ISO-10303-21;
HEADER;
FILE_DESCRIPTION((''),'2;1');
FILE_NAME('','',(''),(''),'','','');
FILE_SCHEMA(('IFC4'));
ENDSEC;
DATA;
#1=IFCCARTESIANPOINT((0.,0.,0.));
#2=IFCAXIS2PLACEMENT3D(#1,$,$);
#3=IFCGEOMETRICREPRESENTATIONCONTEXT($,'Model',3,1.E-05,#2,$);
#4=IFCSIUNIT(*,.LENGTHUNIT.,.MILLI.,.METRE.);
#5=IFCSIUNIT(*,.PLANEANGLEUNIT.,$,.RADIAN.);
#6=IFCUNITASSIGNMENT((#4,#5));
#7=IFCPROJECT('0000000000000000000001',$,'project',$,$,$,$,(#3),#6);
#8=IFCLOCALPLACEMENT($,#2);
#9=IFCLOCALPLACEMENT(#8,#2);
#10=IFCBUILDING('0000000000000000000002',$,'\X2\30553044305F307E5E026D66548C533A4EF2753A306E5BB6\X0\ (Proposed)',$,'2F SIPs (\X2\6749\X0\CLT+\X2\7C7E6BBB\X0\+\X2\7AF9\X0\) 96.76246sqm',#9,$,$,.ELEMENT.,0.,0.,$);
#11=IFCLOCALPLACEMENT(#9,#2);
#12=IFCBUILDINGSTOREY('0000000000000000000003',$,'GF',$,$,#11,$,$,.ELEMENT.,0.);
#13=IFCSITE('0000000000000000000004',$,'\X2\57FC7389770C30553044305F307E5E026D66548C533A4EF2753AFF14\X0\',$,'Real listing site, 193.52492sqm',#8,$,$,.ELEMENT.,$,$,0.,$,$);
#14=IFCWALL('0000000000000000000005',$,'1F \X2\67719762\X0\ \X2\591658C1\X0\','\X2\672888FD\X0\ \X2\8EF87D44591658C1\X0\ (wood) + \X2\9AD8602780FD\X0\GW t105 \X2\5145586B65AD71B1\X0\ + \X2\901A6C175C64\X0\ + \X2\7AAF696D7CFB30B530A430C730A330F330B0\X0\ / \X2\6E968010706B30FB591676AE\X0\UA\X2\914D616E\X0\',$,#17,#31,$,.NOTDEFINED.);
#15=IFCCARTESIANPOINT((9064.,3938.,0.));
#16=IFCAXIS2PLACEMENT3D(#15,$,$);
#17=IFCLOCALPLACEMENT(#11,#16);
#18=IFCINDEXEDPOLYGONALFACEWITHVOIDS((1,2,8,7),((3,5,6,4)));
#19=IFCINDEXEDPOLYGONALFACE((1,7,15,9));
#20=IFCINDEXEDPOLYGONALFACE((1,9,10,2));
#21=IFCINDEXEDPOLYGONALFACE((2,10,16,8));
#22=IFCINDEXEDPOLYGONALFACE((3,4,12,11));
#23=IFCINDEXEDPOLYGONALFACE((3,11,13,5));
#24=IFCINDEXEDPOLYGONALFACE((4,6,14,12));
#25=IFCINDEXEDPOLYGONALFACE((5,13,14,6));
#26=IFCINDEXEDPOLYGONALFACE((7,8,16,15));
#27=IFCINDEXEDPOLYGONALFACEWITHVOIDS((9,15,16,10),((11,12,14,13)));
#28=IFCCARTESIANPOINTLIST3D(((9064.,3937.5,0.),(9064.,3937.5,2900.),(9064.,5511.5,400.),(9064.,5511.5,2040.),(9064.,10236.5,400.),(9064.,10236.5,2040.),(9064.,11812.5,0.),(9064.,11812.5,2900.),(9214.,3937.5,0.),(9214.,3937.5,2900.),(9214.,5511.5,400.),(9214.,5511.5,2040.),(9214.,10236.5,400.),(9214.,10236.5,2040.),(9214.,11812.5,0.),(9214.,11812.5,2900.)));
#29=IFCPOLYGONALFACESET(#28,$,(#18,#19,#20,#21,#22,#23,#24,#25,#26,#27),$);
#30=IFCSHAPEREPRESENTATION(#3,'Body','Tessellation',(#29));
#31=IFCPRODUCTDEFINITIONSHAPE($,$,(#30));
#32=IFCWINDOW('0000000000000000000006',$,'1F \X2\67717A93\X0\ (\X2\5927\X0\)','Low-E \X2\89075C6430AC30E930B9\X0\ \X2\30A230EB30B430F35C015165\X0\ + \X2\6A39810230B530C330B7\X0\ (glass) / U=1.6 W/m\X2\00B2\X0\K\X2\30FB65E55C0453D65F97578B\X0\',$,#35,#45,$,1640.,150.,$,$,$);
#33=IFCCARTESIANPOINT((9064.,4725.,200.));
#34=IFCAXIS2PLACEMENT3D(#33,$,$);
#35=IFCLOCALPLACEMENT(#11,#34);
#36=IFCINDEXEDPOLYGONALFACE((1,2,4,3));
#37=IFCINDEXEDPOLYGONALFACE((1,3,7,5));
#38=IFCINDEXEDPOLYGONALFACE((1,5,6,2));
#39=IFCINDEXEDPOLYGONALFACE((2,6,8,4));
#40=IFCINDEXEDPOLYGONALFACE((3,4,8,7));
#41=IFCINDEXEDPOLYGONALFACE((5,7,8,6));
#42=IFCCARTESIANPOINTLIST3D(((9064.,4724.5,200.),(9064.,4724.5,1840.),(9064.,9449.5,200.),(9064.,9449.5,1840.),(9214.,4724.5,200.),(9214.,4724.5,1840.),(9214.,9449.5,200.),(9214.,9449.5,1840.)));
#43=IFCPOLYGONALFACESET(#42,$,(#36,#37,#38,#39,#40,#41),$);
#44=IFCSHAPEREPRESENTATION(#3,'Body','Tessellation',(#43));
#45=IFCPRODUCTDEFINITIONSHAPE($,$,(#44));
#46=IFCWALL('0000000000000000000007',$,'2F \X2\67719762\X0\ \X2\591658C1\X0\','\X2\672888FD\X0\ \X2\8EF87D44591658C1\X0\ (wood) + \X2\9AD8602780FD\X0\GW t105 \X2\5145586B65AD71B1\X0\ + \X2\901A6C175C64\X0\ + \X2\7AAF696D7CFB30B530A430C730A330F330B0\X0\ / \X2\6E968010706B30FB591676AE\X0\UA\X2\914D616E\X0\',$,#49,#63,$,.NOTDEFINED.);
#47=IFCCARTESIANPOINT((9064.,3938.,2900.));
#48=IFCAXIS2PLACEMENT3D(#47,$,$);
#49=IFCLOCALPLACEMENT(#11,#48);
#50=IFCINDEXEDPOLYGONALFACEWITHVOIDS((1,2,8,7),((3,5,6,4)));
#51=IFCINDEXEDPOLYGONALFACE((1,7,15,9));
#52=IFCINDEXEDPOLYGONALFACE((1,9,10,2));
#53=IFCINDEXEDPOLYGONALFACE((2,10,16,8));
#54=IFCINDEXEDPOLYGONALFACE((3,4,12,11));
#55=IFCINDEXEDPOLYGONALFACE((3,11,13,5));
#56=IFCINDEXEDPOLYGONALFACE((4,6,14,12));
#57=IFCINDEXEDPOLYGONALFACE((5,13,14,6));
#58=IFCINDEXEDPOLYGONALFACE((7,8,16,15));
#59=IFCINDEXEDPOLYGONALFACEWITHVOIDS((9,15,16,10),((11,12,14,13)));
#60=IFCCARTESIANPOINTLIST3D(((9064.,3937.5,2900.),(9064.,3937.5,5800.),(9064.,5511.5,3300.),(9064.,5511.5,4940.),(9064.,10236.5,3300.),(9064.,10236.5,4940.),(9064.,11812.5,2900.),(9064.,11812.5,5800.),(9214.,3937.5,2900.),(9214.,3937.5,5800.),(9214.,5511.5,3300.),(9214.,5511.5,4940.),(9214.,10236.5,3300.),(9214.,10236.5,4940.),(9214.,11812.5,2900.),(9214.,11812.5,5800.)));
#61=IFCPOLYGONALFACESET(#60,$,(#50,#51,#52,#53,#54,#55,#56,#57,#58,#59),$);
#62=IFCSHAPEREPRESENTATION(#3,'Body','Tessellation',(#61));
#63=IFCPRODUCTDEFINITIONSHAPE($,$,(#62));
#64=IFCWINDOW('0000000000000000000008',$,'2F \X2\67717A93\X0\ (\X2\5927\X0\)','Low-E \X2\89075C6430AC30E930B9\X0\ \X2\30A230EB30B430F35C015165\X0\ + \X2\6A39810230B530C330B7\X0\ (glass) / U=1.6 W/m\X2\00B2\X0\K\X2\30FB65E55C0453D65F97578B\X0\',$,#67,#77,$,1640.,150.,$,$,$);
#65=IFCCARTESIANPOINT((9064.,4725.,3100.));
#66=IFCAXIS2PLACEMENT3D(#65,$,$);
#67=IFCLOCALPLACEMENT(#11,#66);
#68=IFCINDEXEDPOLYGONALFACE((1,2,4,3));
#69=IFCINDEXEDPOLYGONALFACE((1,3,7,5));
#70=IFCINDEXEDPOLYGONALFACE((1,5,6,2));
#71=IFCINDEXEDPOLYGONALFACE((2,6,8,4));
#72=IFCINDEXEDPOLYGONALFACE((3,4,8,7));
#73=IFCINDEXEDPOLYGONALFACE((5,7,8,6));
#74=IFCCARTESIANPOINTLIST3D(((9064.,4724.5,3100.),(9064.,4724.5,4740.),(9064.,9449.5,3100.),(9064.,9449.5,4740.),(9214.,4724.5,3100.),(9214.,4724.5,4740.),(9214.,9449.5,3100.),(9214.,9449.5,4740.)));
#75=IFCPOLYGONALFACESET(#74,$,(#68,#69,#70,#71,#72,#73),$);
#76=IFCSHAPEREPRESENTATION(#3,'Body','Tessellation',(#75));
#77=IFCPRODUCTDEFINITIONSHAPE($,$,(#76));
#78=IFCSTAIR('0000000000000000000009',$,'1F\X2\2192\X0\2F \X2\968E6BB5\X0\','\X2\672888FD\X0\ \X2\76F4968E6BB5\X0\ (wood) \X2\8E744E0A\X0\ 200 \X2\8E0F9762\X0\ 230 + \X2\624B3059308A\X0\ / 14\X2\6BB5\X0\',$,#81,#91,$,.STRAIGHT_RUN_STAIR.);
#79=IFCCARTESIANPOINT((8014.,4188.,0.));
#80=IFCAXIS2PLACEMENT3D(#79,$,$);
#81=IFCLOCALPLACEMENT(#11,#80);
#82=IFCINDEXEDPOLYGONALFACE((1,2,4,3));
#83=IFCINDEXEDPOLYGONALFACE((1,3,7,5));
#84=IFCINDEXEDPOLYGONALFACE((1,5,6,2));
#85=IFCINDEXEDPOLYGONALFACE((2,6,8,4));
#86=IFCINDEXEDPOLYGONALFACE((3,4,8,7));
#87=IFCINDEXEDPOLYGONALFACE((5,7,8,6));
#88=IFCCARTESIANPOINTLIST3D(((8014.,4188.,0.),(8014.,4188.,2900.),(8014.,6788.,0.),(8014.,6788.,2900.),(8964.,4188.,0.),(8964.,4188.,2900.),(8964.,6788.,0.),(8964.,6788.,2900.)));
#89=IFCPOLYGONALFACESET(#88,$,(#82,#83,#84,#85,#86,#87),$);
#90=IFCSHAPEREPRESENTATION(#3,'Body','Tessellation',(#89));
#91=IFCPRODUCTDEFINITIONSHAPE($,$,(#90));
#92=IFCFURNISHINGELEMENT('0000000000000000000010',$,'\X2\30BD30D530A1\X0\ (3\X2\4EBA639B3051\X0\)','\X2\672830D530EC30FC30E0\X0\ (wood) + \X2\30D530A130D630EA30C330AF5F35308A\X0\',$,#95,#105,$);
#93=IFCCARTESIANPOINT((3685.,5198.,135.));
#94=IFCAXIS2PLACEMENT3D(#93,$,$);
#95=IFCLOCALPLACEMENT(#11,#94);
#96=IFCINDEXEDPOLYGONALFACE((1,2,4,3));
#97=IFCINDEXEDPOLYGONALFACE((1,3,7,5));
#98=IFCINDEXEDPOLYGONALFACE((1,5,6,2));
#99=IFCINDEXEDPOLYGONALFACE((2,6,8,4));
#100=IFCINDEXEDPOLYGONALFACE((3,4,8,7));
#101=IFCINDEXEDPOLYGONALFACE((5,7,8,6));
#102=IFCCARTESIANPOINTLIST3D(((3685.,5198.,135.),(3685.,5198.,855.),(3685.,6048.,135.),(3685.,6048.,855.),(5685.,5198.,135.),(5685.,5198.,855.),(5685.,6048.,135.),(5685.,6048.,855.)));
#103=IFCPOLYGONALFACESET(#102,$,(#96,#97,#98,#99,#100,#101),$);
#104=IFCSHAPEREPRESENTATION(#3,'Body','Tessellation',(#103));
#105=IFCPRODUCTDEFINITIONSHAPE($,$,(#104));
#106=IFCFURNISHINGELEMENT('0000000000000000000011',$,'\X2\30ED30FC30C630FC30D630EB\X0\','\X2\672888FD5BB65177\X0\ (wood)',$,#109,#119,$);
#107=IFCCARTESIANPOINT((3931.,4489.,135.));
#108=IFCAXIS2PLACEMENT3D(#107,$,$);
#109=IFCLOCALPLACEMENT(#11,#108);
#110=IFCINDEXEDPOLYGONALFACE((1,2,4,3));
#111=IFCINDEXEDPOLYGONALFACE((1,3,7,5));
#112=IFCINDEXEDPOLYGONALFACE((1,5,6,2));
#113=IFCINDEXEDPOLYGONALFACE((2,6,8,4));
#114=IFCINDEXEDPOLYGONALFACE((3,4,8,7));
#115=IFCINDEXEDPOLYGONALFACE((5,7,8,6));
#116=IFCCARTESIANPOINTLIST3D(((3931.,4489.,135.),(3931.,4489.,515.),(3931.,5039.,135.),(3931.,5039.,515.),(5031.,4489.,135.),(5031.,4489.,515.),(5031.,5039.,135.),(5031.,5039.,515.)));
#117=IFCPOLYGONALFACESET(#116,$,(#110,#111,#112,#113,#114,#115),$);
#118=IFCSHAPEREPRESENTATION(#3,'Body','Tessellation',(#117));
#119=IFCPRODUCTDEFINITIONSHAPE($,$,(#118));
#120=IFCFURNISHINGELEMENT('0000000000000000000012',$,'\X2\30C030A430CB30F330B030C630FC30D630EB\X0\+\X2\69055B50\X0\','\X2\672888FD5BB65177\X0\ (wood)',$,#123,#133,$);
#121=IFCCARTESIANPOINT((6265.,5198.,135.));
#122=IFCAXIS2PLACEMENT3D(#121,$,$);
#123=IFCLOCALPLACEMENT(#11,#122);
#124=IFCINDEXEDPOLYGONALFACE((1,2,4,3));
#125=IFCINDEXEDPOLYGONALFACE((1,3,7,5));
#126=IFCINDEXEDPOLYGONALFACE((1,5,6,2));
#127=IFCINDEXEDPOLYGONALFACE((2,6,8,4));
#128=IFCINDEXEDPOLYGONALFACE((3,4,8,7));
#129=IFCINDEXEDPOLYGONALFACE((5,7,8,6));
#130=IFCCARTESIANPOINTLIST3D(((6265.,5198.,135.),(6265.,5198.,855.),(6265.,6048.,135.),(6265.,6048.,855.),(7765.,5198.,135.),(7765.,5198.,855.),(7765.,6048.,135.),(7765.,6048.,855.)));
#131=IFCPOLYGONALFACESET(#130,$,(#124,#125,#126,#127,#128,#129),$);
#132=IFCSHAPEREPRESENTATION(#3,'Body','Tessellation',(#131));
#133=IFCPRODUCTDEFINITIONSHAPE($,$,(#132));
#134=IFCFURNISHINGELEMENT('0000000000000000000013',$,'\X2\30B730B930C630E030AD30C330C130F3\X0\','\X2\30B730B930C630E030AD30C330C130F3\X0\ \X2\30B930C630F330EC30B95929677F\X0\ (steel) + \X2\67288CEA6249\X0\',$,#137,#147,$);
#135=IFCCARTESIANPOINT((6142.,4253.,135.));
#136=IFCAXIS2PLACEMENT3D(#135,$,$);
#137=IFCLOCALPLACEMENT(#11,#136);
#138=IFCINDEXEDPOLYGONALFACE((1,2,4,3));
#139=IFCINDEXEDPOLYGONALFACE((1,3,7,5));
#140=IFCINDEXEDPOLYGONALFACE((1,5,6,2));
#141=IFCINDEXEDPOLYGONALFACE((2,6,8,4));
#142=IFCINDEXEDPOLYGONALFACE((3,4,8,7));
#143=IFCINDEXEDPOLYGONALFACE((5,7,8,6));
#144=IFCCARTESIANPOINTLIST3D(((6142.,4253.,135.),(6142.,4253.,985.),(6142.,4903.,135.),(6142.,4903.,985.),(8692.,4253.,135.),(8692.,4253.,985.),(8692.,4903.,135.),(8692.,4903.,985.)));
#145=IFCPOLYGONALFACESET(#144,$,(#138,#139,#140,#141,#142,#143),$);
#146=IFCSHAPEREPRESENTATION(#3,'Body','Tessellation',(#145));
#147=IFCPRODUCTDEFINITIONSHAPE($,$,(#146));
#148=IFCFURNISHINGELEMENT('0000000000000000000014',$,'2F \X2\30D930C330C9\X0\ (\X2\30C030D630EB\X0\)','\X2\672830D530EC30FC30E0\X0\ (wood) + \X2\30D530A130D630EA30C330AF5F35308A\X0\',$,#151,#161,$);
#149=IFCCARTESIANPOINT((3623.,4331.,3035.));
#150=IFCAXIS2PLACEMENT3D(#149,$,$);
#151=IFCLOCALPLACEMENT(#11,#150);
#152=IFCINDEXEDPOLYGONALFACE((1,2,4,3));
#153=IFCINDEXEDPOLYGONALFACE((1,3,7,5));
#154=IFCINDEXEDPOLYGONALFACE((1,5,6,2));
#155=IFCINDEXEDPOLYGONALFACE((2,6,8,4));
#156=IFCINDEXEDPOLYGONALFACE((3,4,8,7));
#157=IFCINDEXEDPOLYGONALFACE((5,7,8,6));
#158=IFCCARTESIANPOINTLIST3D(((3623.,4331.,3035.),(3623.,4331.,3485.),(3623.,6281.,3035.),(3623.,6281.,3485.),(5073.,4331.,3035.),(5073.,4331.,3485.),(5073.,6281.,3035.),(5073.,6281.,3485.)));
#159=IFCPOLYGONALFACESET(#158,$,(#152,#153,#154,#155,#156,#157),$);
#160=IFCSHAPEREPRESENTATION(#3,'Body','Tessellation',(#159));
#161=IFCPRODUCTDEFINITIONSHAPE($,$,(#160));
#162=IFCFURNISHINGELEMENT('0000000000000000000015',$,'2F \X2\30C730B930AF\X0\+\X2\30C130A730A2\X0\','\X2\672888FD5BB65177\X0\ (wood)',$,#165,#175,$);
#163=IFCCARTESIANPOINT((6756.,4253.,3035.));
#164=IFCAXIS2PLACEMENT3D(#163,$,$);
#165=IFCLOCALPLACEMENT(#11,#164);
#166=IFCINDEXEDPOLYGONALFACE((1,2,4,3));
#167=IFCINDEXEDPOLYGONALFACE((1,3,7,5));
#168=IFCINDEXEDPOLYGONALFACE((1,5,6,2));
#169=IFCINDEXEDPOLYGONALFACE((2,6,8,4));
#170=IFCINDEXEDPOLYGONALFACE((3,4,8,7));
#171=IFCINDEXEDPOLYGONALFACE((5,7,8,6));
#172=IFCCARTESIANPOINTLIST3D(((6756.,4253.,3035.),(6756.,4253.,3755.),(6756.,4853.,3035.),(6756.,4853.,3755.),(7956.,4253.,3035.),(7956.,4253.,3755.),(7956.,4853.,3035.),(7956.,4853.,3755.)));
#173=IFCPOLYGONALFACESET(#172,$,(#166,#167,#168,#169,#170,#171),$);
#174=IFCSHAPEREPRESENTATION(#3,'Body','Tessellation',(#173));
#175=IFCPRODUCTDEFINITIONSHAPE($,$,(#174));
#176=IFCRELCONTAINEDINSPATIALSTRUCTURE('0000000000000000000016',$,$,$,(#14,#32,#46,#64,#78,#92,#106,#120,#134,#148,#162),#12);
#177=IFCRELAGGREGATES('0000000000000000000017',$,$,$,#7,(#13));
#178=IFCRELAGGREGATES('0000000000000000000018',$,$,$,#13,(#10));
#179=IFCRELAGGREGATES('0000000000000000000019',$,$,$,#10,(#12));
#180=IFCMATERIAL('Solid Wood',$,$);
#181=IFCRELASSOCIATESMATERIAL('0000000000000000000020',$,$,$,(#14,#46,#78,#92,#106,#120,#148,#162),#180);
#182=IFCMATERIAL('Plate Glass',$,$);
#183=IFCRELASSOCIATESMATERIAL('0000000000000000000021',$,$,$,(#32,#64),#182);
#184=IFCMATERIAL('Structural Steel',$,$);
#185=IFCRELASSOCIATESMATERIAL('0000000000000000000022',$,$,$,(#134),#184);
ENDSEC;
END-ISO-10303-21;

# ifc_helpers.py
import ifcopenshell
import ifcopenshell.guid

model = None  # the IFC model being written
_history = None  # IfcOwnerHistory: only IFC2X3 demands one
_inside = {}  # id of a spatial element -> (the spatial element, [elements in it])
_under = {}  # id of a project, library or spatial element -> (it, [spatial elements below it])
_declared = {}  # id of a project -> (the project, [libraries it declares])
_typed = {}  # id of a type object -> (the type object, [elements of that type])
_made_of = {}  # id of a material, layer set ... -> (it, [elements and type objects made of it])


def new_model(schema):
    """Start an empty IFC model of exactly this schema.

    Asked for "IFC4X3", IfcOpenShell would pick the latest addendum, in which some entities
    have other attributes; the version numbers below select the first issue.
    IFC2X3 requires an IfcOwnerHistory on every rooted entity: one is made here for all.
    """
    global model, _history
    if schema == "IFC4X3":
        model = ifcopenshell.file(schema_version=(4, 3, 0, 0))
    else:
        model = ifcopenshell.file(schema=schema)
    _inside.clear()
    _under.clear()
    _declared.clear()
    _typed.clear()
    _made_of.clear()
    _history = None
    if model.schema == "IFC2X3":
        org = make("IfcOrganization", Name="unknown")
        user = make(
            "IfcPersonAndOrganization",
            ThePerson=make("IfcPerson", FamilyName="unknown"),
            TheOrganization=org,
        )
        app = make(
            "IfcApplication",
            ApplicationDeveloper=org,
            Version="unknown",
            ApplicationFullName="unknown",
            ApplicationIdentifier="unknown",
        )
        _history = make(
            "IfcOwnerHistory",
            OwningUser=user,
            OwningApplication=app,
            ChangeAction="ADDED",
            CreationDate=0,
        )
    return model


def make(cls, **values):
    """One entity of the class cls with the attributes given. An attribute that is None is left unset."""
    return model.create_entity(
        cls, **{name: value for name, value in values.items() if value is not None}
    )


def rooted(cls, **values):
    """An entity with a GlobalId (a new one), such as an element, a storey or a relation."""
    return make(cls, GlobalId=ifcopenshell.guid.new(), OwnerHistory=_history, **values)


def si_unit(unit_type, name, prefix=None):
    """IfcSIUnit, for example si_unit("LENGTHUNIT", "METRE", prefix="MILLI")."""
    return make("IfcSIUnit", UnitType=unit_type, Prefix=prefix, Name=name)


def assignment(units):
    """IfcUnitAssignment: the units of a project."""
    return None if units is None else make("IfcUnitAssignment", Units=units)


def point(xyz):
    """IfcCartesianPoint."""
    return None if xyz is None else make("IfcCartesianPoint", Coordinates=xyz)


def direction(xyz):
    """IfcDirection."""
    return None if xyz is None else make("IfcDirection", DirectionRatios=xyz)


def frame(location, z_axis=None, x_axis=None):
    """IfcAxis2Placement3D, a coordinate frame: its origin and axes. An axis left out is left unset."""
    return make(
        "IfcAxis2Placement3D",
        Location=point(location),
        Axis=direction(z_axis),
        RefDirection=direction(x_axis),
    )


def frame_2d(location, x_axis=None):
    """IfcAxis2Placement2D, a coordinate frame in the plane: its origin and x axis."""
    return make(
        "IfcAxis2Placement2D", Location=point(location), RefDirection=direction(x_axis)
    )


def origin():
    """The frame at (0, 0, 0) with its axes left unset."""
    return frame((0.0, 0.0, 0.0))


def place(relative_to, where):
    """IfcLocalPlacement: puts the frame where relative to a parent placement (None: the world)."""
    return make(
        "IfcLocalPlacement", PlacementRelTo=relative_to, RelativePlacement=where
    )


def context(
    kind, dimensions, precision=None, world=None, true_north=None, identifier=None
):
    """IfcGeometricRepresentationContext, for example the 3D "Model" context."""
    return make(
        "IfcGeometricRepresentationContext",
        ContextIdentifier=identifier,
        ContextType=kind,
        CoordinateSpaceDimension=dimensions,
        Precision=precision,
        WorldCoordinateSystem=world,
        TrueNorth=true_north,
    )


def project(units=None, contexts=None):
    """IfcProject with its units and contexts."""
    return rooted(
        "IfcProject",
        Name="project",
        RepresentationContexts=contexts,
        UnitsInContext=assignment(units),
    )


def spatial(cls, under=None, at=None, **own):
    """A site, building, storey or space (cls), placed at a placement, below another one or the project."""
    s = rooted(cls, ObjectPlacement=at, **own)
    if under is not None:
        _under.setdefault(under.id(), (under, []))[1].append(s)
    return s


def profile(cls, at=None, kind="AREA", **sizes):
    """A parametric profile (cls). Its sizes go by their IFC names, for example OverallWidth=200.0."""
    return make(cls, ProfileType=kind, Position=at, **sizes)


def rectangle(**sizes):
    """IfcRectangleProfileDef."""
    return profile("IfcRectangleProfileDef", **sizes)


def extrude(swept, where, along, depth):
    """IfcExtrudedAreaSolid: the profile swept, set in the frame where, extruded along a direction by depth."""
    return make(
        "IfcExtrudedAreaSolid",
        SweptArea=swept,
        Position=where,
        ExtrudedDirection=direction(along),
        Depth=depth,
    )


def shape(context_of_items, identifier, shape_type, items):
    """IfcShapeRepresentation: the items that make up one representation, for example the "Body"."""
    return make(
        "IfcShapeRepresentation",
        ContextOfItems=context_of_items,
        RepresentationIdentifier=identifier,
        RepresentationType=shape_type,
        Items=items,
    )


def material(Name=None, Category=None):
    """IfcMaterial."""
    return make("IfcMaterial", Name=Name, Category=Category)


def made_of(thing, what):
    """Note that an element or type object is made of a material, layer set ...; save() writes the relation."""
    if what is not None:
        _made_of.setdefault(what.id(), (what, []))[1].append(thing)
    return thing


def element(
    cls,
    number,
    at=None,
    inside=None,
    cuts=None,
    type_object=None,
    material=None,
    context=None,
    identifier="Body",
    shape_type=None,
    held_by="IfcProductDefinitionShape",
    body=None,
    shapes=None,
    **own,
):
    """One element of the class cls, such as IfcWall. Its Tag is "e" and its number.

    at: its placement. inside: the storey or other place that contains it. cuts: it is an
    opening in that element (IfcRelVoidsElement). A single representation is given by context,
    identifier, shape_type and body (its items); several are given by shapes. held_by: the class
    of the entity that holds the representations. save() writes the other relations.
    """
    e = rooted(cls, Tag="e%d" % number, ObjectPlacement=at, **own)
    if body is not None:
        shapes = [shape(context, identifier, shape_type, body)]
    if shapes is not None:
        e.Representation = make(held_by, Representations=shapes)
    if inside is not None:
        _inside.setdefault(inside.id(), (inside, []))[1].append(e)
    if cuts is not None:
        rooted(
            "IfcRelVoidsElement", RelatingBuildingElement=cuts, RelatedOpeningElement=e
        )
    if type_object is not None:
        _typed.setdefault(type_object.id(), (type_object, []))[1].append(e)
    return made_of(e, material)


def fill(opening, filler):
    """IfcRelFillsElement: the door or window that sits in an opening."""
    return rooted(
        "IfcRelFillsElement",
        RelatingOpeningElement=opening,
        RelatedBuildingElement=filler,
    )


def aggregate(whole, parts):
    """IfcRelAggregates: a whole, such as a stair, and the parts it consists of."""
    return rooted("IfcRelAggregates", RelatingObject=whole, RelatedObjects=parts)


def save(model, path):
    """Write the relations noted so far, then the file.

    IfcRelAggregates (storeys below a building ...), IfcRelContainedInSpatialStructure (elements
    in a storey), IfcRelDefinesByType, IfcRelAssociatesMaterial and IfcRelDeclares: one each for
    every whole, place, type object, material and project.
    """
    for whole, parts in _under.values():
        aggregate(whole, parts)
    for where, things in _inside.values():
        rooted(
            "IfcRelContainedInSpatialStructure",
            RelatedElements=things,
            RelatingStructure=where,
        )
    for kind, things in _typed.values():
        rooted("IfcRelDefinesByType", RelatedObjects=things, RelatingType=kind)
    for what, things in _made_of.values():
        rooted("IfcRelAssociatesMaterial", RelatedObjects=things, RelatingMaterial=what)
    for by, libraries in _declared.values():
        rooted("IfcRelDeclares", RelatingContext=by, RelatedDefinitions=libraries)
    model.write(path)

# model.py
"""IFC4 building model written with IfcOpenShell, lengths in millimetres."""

from ifc_helpers import new_model, si_unit, frame, frame_2d, origin, place, context, project, spatial, rectangle, extrude, material, element, fill, save


model = new_model("IFC4")

# Units and contexts
model_context = context("Model", 3, precision=1e-05, world=origin())
ifc_project = project(units=[si_unit("LENGTHUNIT", "METRE", prefix="MILLI"), si_unit("PLANEANGLEUNIT", "RADIAN")], contexts=[model_context])

# Site, building, storey
site_placement = place(None, origin())
site = spatial("IfcSite", under=ifc_project, at=site_placement, Name="埼玉県さいたま市浦和区仲町４", ObjectType="Real listing site, 193.52492sqm", CompositionType="ELEMENT", RefElevation=0.0)
building_placement = place(site_placement, origin())
building = spatial("IfcBuilding", under=site, at=building_placement, Name="さいたま市浦和区仲町の家 (Proposed)", ObjectType="2F SIPs (杉CLT+籾殻+竹) 96.76246sqm", CompositionType="ELEMENT", ElevationOfRefHeight=0.0, ElevationOfTerrain=0.0)
storey_placement = place(building_placement, origin())
storey = spatial("IfcBuildingStorey", under=building, at=storey_placement, Name="GF", CompositionType="ELEMENT", Elevation=0.0)

# Wall, opening, window
ifc_material_1 = material(Name="Solid Wood")
wall_1_placement = place(storey_placement, frame((9064.0, 3938.0, 0.0)))
wall_1 = element("IfcWall", 1, at=wall_1_placement, inside=storey, material=ifc_material_1, Name="1F 東面 外壁", Description="木製 軸組外壁 (wood) + 高性能GW t105 充填断熱 + 通気層 + 窯業系サイディング / 準耐火・外皮UA配慮", PredefinedType="NOTDEFINED", context=model_context, shape_type="SweptSolid", body=[
    extrude(rectangle(XDim=150.0, YDim=7875.0, at=frame_2d((75.0, 3937.0))), frame((9064.0, 3938.0, 0.0)), (0.0, 0.0, 1.0), 2900.0),
])
opening_1_placement = place(storey_placement, frame((9064.0, 4725.0, 200.0)))
opening_1 = element("IfcOpeningElement", 2, at=opening_1_placement, cuts=wall_1, PredefinedType="NOTDEFINED", context=model_context, shape_type="SweptSolid", body=[
    extrude(rectangle(XDim=150.0, YDim=4725.0, at=frame_2d((75.0, 2362.0))), frame((9064.0, 4725.0, 200.0)), (0.0, 0.0, 1.0), 1640.0),
])
ifc_material_2 = material(Name="Plate Glass")
window_1_placement = place(storey_placement, frame((9064.0, 4725.0, 200.0)))
window_1 = element("IfcWindow", 3, at=window_1_placement, inside=storey, material=ifc_material_2, Name="1F 東窓 (大)", Description="Low-E 複層ガラス アルゴン封入 + 樹脂サッシ (glass) / U=1.6 W/m²K・日射取得型", OverallHeight=1640.0, OverallWidth=150.0, context=model_context, shape_type="SweptSolid", body=[
    extrude(rectangle(XDim=150.0, YDim=4725.0, at=frame_2d((75.0, 2362.0))), frame((9064.0, 4725.0, 200.0)), (0.0, 0.0, 1.0), 1640.0),
])
fill(opening_1, window_1)

# Wall, opening, window
wall_2_placement = place(storey_placement, frame((9064.0, 3938.0, 2900.0)))
wall_2 = element("IfcWall", 4, at=wall_2_placement, inside=storey, material=ifc_material_1, Name="2F 東面 外壁", Description="木製 軸組外壁 (wood) + 高性能GW t105 充填断熱 + 通気層 + 窯業系サイディング / 準耐火・外皮UA配慮", PredefinedType="NOTDEFINED", context=model_context, shape_type="SweptSolid", body=[
    extrude(rectangle(XDim=150.0, YDim=7875.0, at=frame_2d((75.0, 3937.0))), frame((9064.0, 3938.0, 2900.0)), (0.0, 0.0, 1.0), 2900.0),
])
opening_2_placement = place(storey_placement, frame((9064.0, 4725.0, 3100.0)))
opening_2 = element("IfcOpeningElement", 5, at=opening_2_placement, cuts=wall_2, PredefinedType="NOTDEFINED", context=model_context, shape_type="SweptSolid", body=[
    extrude(rectangle(XDim=150.0, YDim=4725.0, at=frame_2d((75.0, 2362.0))), frame((9064.0, 4725.0, 3100.0)), (0.0, 0.0, 1.0), 1640.0),
])
window_2_placement = place(storey_placement, frame((9064.0, 4725.0, 3100.0)))
window_2 = element("IfcWindow", 6, at=window_2_placement, inside=storey, material=ifc_material_2, Name="2F 東窓 (大)", Description="Low-E 複層ガラス アルゴン封入 + 樹脂サッシ (glass) / U=1.6 W/m²K・日射取得型", OverallHeight=1640.0, OverallWidth=150.0, context=model_context, shape_type="SweptSolid", body=[
    extrude(rectangle(XDim=150.0, YDim=4725.0, at=frame_2d((75.0, 2362.0))), frame((9064.0, 4725.0, 3100.0)), (0.0, 0.0, 1.0), 1640.0),
])
fill(opening_2, window_2)

# Stair
stair_placement = place(storey_placement, frame((8014.0, 4188.0, 0.0)))
element("IfcStair", 7, at=stair_placement, inside=storey, material=ifc_material_1, Name="1F→2F 階段", Description="木製 直階段 (wood) 蹴上 200 踏面 230 + 手すり / 14段", PredefinedType="STRAIGHT_RUN_STAIR", context=model_context, shape_type="SweptSolid", body=[
    extrude(rectangle(XDim=950.0, YDim=2600.0, at=frame_2d((475.0, 1300.0))), frame((8014.0, 4188.0, 0.0)), (0.0, 0.0, 1.0), 2900.0),
])

# Furnishing elements
furnishing_1_placement = place(storey_placement, frame((3685.0, 5198.0, 135.0)))
element("IfcFurnishingElement", 8, at=furnishing_1_placement, inside=storey, material=ifc_material_1, Name="ソファ (3人掛け)", Description="木フレーム (wood) + ファブリック張り", context=model_context, shape_type="SweptSolid", body=[
    extrude(rectangle(XDim=2000.0, YDim=850.0, at=frame_2d((1000.0, 425.0))), frame((3685.0, 5198.0, 135.0)), (0.0, 0.0, 1.0), 720.0),
])
furnishing_2_placement = place(storey_placement, frame((3931.0, 4489.0, 135.0)))
element("IfcFurnishingElement", 9, at=furnishing_2_placement, inside=storey, material=ifc_material_1, Name="ローテーブル", Description="木製家具 (wood)", context=model_context, shape_type="SweptSolid", body=[
    extrude(rectangle(XDim=1100.0, YDim=550.0, at=frame_2d((550.0, 275.0))), frame((3931.0, 4489.0, 135.0)), (0.0, 0.0, 1.0), 380.0),
])
furnishing_3_placement = place(storey_placement, frame((6265.0, 5198.0, 135.0)))
element("IfcFurnishingElement", 10, at=furnishing_3_placement, inside=storey, material=ifc_material_1, Name="ダイニングテーブル+椅子", Description="木製家具 (wood)", context=model_context, shape_type="SweptSolid", body=[
    extrude(rectangle(XDim=1500.0, YDim=850.0, at=frame_2d((750.0, 425.0))), frame((6265.0, 5198.0, 135.0)), (0.0, 0.0, 1.0), 720.0),
])
ifc_material_3 = material(Name="Structural Steel")
furnishing_4_placement = place(storey_placement, frame((6142.0, 4253.0, 135.0)))
element("IfcFurnishingElement", 11, at=furnishing_4_placement, inside=storey, material=ifc_material_3, Name="システムキッチン", Description="システムキッチン ステンレス天板 (steel) + 木質扉", context=model_context, shape_type="SweptSolid", body=[
    extrude(rectangle(XDim=2550.0, YDim=650.0, at=frame_2d((1275.0, 325.0))), frame((6142.0, 4253.0, 135.0)), (0.0, 0.0, 1.0), 850.0),
])
furnishing_5_placement = place(storey_placement, frame((3623.0, 4331.0, 3035.0)))
element("IfcFurnishingElement", 12, at=furnishing_5_placement, inside=storey, material=ifc_material_1, Name="2F ベッド (ダブル)", Description="木フレーム (wood) + ファブリック張り", context=model_context, shape_type="SweptSolid", body=[
    extrude(rectangle(XDim=1450.0, YDim=1950.0, at=frame_2d((725.0, 975.0))), frame((3623.0, 4331.0, 3035.0)), (0.0, 0.0, 1.0), 450.0),
])
furnishing_6_placement = place(storey_placement, frame((6756.0, 4253.0, 3035.0)))
element("IfcFurnishingElement", 13, at=furnishing_6_placement, inside=storey, material=ifc_material_1, Name="2F デスク+チェア", Description="木製家具 (wood)", context=model_context, shape_type="SweptSolid", body=[
    extrude(rectangle(XDim=1200.0, YDim=600.0, at=frame_2d((600.0, 300.0))), frame((6756.0, 4253.0, 3035.0)), (0.0, 0.0, 1.0), 720.0),
])

save(model, "model.ifc")
